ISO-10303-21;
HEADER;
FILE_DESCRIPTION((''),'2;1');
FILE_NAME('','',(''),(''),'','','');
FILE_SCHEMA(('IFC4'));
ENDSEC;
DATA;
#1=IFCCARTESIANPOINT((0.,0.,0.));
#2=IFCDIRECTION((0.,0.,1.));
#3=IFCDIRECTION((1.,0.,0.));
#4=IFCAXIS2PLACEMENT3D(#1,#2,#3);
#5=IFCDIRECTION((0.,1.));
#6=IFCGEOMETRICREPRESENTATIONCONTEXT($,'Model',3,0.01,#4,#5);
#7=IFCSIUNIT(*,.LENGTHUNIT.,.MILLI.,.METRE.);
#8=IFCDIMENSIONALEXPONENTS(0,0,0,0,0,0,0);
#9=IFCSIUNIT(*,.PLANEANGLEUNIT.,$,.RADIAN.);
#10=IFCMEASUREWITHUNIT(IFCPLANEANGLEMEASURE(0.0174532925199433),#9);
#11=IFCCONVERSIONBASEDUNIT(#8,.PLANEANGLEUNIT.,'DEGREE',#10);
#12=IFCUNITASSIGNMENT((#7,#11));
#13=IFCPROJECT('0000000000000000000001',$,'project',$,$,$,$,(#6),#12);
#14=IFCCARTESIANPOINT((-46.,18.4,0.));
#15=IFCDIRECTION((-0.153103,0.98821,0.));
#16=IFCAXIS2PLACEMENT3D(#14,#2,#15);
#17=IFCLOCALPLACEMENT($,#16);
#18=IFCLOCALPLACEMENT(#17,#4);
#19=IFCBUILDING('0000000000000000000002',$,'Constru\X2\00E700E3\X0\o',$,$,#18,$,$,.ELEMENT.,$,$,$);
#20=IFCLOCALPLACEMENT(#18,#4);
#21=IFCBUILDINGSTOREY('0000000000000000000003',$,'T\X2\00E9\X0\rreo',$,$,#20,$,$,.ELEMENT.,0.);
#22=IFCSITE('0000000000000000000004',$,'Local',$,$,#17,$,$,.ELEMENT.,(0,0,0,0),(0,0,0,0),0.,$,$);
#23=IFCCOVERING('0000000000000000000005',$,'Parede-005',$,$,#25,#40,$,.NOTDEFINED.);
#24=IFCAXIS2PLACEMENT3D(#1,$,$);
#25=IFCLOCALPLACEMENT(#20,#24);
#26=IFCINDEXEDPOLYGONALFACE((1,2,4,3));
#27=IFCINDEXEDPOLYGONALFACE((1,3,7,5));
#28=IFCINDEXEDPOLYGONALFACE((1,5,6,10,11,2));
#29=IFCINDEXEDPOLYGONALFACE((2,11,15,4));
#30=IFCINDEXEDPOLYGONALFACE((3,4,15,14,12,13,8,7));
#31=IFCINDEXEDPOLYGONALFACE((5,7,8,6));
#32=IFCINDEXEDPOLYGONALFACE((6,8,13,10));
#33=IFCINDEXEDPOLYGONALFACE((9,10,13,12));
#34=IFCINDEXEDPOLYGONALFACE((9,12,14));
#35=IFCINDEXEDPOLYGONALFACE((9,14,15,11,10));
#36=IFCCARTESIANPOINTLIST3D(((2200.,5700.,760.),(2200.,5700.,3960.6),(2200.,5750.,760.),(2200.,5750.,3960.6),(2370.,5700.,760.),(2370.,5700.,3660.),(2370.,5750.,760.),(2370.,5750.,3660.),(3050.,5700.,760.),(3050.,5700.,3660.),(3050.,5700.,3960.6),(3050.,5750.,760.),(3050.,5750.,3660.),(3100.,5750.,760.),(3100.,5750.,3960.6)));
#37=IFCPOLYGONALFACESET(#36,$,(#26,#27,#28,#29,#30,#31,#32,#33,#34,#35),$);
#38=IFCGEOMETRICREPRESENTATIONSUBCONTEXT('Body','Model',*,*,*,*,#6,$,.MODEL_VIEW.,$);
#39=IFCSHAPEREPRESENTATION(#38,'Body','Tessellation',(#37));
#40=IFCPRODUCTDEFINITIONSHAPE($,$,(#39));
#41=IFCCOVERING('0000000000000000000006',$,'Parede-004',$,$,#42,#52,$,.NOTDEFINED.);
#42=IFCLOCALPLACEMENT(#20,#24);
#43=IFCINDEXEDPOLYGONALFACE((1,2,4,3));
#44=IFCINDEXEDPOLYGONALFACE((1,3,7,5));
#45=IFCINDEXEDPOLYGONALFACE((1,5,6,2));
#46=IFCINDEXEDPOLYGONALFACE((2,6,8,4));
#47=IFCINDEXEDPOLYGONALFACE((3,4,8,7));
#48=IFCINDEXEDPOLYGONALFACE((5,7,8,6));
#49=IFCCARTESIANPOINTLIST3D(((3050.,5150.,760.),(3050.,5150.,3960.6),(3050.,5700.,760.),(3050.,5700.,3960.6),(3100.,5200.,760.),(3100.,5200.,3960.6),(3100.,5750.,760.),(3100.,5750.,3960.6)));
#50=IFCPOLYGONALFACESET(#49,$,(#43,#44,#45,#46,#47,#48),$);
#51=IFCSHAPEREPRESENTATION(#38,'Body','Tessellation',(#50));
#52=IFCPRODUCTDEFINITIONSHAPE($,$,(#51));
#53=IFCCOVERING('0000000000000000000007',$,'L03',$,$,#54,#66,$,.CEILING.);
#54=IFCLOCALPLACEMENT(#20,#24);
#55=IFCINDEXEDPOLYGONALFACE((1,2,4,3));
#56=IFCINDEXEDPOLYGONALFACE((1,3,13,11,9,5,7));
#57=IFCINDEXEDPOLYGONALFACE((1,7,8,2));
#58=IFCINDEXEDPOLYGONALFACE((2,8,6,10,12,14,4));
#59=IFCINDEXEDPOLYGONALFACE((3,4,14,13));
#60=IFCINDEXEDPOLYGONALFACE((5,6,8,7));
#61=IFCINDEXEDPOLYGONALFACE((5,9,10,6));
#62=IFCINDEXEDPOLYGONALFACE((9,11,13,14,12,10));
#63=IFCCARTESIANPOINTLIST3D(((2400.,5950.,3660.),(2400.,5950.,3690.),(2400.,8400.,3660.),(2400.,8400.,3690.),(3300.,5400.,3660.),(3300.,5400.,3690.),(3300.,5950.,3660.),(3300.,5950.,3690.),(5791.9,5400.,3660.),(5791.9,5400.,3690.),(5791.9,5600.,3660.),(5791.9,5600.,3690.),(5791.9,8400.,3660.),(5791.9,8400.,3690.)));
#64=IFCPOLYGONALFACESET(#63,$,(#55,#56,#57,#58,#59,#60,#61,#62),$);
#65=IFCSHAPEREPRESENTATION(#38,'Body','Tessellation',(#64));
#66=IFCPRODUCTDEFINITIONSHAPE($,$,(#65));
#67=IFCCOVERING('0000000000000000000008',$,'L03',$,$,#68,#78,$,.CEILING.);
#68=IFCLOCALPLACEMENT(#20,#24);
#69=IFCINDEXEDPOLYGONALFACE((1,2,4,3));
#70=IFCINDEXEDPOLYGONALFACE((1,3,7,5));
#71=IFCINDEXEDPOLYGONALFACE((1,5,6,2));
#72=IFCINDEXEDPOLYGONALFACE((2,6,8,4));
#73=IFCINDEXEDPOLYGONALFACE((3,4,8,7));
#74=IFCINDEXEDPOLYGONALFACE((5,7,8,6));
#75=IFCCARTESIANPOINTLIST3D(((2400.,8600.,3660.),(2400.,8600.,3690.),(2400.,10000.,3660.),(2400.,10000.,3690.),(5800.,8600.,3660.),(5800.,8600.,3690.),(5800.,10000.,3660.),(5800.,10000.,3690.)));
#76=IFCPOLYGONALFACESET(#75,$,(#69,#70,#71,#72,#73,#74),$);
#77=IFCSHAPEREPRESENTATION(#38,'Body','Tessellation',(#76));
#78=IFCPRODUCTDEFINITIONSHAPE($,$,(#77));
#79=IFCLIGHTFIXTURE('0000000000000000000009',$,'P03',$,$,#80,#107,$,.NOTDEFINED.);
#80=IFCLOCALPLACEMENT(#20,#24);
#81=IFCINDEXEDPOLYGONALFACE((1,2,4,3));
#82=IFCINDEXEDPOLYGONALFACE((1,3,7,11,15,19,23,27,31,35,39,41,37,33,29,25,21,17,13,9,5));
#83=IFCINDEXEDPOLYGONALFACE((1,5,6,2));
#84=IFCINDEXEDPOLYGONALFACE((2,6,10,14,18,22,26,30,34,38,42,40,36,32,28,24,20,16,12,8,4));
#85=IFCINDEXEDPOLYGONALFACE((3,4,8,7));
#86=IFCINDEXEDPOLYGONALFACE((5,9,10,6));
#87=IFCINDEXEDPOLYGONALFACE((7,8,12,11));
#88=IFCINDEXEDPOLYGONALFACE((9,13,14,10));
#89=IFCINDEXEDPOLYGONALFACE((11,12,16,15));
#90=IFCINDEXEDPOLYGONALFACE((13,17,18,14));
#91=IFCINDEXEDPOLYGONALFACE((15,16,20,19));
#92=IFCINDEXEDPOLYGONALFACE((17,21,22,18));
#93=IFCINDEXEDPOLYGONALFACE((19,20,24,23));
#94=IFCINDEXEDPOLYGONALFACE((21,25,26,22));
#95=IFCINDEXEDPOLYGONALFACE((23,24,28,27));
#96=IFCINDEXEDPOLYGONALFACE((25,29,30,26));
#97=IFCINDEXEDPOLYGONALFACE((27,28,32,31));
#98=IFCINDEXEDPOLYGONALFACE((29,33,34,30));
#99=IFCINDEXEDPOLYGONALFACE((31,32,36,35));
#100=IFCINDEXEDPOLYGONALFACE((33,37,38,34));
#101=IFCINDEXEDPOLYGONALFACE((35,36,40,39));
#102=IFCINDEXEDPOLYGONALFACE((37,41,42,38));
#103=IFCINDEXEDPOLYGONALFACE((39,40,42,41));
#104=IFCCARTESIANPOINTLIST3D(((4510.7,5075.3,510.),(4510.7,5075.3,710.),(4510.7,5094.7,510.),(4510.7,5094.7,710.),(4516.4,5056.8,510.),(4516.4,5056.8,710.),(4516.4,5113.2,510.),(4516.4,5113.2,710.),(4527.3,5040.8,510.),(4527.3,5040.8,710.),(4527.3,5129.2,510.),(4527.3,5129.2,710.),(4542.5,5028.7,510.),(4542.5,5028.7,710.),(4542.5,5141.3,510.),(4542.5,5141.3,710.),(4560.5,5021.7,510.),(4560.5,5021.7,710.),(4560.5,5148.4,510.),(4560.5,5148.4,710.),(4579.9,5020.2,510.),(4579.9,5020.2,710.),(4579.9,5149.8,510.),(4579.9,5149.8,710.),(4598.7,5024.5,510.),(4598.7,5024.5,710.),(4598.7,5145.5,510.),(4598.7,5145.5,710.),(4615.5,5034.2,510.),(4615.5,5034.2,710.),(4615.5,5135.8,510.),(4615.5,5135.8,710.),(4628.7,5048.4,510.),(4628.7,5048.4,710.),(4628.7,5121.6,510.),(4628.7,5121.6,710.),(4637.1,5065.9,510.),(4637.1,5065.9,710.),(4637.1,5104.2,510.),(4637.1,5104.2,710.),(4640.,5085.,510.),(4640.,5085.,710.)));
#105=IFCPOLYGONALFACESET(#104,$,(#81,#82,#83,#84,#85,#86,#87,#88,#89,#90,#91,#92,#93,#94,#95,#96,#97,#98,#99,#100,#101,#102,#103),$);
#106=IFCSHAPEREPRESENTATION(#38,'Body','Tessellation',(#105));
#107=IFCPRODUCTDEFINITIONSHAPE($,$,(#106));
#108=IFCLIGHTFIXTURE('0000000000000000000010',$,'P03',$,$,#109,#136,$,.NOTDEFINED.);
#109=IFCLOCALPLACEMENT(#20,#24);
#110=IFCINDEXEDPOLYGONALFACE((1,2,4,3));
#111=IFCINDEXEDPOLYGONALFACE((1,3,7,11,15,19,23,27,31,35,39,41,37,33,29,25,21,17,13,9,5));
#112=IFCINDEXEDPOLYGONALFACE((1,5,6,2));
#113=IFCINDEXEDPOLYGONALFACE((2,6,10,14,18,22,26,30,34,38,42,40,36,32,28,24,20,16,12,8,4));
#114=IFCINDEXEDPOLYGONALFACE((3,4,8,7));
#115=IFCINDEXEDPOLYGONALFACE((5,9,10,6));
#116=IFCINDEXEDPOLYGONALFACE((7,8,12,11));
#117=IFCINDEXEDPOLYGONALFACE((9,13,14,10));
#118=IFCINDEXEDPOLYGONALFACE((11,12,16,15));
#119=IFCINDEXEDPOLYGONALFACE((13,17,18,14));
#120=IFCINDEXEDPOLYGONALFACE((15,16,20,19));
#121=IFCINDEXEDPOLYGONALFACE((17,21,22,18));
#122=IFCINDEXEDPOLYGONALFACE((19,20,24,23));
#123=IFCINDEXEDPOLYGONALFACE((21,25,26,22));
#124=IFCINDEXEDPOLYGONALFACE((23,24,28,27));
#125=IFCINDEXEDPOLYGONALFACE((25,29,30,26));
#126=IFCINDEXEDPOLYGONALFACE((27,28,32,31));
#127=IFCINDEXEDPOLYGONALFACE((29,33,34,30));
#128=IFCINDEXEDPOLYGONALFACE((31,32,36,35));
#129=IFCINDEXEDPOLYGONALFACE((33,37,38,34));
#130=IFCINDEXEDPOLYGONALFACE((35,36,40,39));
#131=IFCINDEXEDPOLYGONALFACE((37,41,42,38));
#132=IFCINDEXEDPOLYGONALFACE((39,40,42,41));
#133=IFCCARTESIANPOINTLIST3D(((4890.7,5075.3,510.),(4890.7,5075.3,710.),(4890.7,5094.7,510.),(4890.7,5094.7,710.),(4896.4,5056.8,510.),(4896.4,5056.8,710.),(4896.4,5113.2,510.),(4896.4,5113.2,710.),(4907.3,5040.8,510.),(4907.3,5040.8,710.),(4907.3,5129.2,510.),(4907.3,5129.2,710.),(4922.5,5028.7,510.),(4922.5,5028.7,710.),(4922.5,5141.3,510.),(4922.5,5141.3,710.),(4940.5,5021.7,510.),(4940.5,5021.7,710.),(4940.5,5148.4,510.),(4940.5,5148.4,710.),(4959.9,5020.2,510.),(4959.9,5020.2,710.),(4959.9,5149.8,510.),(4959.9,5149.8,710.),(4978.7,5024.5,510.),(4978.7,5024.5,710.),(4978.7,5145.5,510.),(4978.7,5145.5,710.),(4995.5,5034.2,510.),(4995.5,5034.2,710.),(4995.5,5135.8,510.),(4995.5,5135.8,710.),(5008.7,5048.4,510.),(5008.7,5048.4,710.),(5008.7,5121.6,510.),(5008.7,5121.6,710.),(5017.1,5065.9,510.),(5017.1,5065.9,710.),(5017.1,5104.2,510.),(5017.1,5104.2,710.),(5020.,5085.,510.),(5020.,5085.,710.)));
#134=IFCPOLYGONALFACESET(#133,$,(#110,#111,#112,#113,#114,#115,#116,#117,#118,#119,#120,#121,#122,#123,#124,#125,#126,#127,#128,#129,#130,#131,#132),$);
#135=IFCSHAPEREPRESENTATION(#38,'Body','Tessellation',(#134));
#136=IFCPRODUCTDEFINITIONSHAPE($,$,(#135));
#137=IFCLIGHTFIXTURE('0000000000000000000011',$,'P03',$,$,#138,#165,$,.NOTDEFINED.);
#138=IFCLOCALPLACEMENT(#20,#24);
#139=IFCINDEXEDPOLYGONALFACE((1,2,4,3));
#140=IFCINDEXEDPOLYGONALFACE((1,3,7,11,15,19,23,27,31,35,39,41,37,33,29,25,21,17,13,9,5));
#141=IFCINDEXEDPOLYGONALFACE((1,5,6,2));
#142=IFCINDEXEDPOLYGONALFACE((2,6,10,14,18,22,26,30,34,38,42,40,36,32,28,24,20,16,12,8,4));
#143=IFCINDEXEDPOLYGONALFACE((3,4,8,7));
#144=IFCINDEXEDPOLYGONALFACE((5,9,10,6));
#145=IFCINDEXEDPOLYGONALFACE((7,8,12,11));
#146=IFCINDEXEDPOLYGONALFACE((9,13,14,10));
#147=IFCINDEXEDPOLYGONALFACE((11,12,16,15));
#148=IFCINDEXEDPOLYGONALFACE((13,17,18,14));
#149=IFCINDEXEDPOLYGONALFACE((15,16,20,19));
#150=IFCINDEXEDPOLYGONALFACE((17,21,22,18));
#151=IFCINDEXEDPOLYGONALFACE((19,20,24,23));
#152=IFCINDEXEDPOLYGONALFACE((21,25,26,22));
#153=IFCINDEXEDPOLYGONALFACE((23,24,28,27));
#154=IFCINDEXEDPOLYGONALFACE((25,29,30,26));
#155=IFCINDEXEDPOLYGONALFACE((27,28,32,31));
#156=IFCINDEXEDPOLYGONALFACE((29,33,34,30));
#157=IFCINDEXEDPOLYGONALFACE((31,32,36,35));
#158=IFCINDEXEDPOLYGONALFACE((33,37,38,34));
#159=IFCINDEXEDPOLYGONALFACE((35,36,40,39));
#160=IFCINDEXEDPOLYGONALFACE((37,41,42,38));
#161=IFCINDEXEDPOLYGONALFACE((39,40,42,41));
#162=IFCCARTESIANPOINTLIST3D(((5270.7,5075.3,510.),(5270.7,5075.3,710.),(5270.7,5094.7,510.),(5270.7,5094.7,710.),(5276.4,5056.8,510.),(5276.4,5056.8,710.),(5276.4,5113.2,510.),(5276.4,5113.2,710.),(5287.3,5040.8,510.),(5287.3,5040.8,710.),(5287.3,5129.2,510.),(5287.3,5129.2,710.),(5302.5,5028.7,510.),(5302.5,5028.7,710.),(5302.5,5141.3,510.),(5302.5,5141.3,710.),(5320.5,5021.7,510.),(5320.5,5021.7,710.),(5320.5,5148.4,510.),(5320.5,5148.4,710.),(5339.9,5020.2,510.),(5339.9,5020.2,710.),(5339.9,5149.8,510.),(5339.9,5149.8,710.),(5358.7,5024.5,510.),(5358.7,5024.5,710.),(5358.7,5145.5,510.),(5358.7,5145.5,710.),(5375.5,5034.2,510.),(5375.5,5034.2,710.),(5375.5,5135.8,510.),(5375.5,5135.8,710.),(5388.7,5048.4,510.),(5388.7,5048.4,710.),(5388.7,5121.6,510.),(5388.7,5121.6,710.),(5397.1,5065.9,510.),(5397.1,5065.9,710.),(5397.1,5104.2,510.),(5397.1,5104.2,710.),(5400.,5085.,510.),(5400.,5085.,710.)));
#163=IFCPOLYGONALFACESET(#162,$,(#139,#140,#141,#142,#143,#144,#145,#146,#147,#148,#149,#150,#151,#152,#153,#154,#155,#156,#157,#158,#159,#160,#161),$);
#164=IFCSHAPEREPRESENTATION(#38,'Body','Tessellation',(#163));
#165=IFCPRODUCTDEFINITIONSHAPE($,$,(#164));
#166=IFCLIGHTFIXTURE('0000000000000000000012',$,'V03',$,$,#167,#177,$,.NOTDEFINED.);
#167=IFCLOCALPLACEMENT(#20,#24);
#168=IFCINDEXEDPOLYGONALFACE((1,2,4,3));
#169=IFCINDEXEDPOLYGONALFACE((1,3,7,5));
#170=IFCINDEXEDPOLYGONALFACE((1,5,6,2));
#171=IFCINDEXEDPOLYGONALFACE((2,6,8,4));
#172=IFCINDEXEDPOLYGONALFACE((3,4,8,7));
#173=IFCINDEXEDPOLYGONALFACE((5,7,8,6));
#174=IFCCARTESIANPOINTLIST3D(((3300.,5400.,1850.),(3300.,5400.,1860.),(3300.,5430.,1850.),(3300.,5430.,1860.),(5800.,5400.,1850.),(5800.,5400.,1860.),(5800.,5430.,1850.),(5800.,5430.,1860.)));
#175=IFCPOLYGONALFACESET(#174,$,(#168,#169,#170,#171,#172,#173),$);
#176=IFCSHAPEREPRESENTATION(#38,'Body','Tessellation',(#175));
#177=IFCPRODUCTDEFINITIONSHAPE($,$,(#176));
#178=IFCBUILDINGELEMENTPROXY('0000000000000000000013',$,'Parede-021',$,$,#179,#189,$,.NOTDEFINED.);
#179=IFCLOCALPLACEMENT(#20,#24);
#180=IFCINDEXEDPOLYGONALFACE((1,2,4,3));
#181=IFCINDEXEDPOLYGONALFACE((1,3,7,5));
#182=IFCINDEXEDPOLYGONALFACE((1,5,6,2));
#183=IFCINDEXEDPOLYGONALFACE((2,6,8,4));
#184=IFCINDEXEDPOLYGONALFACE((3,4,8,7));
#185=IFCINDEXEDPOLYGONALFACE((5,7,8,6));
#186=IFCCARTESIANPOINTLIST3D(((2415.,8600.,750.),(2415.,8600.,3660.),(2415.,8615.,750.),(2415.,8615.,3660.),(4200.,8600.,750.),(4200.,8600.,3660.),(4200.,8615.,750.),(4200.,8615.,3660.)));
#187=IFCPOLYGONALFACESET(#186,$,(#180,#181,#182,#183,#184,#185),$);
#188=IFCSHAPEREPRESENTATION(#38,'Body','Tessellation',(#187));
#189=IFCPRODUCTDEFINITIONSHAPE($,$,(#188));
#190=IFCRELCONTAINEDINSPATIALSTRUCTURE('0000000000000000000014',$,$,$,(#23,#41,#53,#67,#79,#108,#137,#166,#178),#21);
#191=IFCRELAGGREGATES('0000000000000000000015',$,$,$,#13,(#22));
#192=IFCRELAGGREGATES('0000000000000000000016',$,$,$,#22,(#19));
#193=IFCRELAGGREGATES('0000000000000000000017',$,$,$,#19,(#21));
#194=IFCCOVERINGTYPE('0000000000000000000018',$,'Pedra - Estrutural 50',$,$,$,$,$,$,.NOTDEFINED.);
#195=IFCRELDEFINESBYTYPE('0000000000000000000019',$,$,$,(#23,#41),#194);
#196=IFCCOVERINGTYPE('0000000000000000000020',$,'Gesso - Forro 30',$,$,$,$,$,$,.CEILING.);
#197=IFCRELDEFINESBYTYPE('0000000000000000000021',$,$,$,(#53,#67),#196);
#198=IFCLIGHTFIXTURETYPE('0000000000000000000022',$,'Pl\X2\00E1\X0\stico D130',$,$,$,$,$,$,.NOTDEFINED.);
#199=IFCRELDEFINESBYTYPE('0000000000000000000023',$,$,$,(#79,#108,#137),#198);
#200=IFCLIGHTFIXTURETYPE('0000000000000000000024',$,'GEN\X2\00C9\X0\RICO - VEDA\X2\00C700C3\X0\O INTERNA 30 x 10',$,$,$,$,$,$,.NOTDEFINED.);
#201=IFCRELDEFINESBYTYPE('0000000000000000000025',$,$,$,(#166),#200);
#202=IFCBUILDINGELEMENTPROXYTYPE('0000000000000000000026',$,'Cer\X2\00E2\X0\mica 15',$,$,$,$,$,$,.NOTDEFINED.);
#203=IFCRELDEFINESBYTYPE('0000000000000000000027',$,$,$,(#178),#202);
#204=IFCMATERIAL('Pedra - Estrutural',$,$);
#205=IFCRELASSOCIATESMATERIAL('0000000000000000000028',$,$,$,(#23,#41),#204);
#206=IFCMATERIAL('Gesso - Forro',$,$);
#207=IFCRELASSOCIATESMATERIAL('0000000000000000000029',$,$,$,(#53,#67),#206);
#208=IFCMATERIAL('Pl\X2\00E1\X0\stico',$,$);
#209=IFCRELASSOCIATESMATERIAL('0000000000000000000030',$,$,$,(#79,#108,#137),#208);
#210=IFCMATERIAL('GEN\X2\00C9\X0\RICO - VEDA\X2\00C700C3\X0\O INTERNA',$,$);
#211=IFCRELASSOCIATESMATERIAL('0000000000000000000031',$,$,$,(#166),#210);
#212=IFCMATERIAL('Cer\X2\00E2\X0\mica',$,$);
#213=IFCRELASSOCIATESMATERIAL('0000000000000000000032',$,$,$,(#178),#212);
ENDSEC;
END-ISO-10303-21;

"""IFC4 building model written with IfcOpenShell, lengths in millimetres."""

from ifc_helpers import new_model, entity, si_unit, converted_unit, direction, frame, frame_2d, origin_with_axes, origin_2d_with_axis, place, context, subcontext, project, spatial, line, indexed_curve, rectangle, circle, outline, extrude, material, type_object, element, save


model = new_model("IFC4")

# Units and contexts
model_context = context("Model", 3, precision=0.01, world=origin_with_axes(), true_north=direction((0.0, 1.0)))
body_context = subcontext(model_context, "Body", "Model", "MODEL_VIEW")
ifc_project = project(units=[si_unit("LENGTHUNIT", "METRE", prefix="MILLI"), converted_unit("PLANEANGLEUNIT", "DEGREE", entity("IfcPlaneAngleMeasure", 0.0174532925199433), si_unit("PLANEANGLEUNIT", "RADIAN"), dimensions=[0, 0, 0, 0, 0, 0, 0])], contexts=[model_context])

# Site, building, storey
site_placement = place(None, frame((-46.0, 18.4, 0.0), z_axis=(0.0, 0.0, 1.0), x_axis=(-0.153103, 0.98821, 0.0)))
site = spatial("IfcSite", under=ifc_project, at=site_placement, Name="Local", CompositionType="ELEMENT", RefLatitude=(0, 0, 0, 0), RefLongitude=(0, 0, 0, 0), RefElevation=0.0)
building_placement = place(site_placement, origin_with_axes())
building = spatial("IfcBuilding", under=site, at=building_placement, Name="Construção", CompositionType="ELEMENT")
storey_placement = place(building_placement, origin_with_axes())
storey = spatial("IfcBuildingStorey", under=building, at=storey_placement, Name="Térreo", CompositionType="ELEMENT", Elevation=0.0)

# Shared definitions
ifc_material_1 = material(Name="GENÉRICO - VEDAÇÃO INTERNA")

# Covering, opening
ifc_material_2 = material(Name="Pedra - Estrutural")
covering_type_1 = type_object("IfcCoveringType", Name="Pedra - Estrutural 50", PredefinedType="NOTDEFINED")
covering_1_placement = place(storey_placement, frame((3100.0, 5750.0, 760.0), z_axis=(0.0, 0.0, 1.0), x_axis=(-1.0, 0.0, 0.0)))
covering_1 = element("IfcCovering", 1, at=covering_1_placement, inside=storey, type_object=covering_type_1, material=ifc_material_2, Name="Parede-005", PredefinedType="NOTDEFINED", context=body_context, shape_type="SweptSolid", body=[
    extrude(outline(indexed_curve([(0.0, 0.0), (900.0, 0.0), (900.0, 50.0), (50.0, 50.0)], segments=[line(1, 2, 3, 4, 1)])), origin_with_axes(), (0.0, 0.0, 1.0), 3200.6),
])
opening_1_placement = place(covering_1_placement, frame((390.0, 0.0, 0.0), z_axis=(0.0, 0.0, 1.0), x_axis=(1.0, 0.0, 0.0)))
element("IfcOpeningElement", 2, at=opening_1_placement, cuts=covering_1, context=body_context, shape_type="SweptSolid", body=[
    extrude(rectangle(XDim=680.0, YDim=2900.0, at=origin_2d_with_axis()), frame((0.0, -50.0, 1450.0), z_axis=(0.0, 1.0, 0.0), x_axis=(-1.0, 0.0, 0.0)), (0.0, 0.0, 1.0), 150.0),
])

# Coverings
covering_2_placement = place(storey_placement, frame((3100.0, 5200.0, 760.0), z_axis=(0.0, 0.0, 1.0), x_axis=(-0.000001, 1.0, 0.0)))
element("IfcCovering", 3, at=covering_2_placement, inside=storey, type_object=covering_type_1, material=ifc_material_2, Name="Parede-004", PredefinedType="NOTDEFINED", context=body_context, shape_type="SweptSolid", body=[
    extrude(outline(indexed_curve([(0.0, 0.0), (550.0, 0.0), (500.0, 50.0), (-50.0, 50.0)], segments=[line(1, 2, 3, 4, 1)])), origin_with_axes(), (0.0, 0.0, 1.0), 3200.6),
])
ifc_material_3 = material(Name="Gesso - Forro")
covering_type_2 = type_object("IfcCoveringType", Name="Gesso - Forro 30", PredefinedType="CEILING")
covering_3_placement = place(storey_placement, frame((2400.0, 8400.0, 3690.0), z_axis=(0.0, 0.0, 1.0), x_axis=(1.0, 0.0, 0.0)))
element("IfcCovering", 4, at=covering_3_placement, inside=storey, type_object=covering_type_2, material=ifc_material_3, Name="L03", PredefinedType="CEILING", context=body_context, shape_type="SweptSolid", body=[
    extrude(outline(indexed_curve([(0.0, 0.0), (0.0, -2450.0), (900.0, -2450.0), (900.0, -3000.0), (3391.9, -3000.0), (3391.9, -2800.0), (3391.9, 0.0)], segments=[line(1, 2, 3, 4, 5, 6, 7, 1)])), frame((0.0, 0.0, -30.0), z_axis=(0.0, 0.0, 1.0), x_axis=(1.0, 0.0, 0.0)), (0.0, 0.0, 1.0), 30.0),
])
covering_4_placement = place(storey_placement, frame((2400.0, 8600.0, 3690.0), z_axis=(0.0, 0.0, 1.0), x_axis=(1.0, 0.0, 0.0)))
element("IfcCovering", 5, at=covering_4_placement, inside=storey, type_object=covering_type_2, material=ifc_material_3, Name="L03", PredefinedType="CEILING", context=body_context, shape_type="SweptSolid", body=[
    extrude(outline(indexed_curve([(0.0, 0.0), (3400.0, 0.0), (3400.0, 1400.0), (0.0, 1400.0)], segments=[line(1, 2, 3, 4, 1)])), frame((0.0, 0.0, -30.0), z_axis=(0.0, 0.0, 1.0), x_axis=(1.0, 0.0, 0.0)), (0.0, 0.0, 1.0), 30.0),
])

# Light fixtures
ifc_material_4 = material(Name="Plástico")
light_fixture_type_1 = type_object("IfcLightFixtureType", Name="Plástico D130", PredefinedType="NOTDEFINED")
for number, where, z_axis, x_axis, name in (
    (6, (4575.0, 5085.0, 510.0), (0.0, 0.0, 1.0), (1.0, 0.0, 0.0), "P03"),
    (7, (4955.0, 5085.0, 510.0), (0.0, 0.0, 1.0), (1.0, 0.0, 0.0), "P03"),
    (8, (5335.0, 5085.0, 510.0), (0.0, 0.0, 1.0), (1.0, 0.0, 0.0), "P03"),
):
    element("IfcLightFixture", number, at=place(storey_placement, frame(where, z_axis=z_axis, x_axis=x_axis)), inside=storey, type_object=light_fixture_type_1, material=ifc_material_4, Name=name, PredefinedType="NOTDEFINED", context=body_context, shape_type="SweptSolid", body=[
        extrude(circle(Radius=65.0, at=origin_2d_with_axis()), origin_with_axes(), (0.0, 0.0, 1.0), 200.0),
    ])
light_fixture_type_2 = type_object("IfcLightFixtureType", Name="GENÉRICO - VEDAÇÃO INTERNA 30 x 10", PredefinedType="NOTDEFINED")
light_fixture_placement = place(storey_placement, frame((3300.0, 5400.0, 1860.0), z_axis=(0.0, 0.0, 1.0), x_axis=(0.0, -1.0, 0.0)))
element("IfcLightFixture", 9, at=light_fixture_placement, inside=storey, type_object=light_fixture_type_2, material=ifc_material_1, Name="V03", PredefinedType="NOTDEFINED", context=body_context, shape_type="SweptSolid", body=[
    extrude(rectangle(XDim=10.0, YDim=30.0, at=frame_2d((-5.0, -15.0), x_axis=(1.0, 0.0))), frame((0.0, 0.0, 0.0), z_axis=(0.0, 1.0, 0.0), x_axis=(0.0, 0.0, 1.0)), (0.0, 0.0, 1.0), 2500.0),
])

# Building element proxy
ifc_material_5 = material(Name="Cerâmica")
building_element_proxy_type_1 = type_object("IfcBuildingElementProxyType", Name="Cerâmica 15", PredefinedType="NOTDEFINED")
proxy_1_placement = place(storey_placement, frame((2415.0, 8600.0, 750.0), z_axis=(0.0, 0.0, 1.0), x_axis=(1.0, 0.0, 0.0)))
element("IfcBuildingElementProxy", 10, at=proxy_1_placement, inside=storey, type_object=building_element_proxy_type_1, material=ifc_material_5, Name="Parede-021", PredefinedType="NOTDEFINED", context=body_context, shape_type="SweptSolid", body=[
    extrude(outline(indexed_curve([(0.0, 0.0), (1785.0, 0.0), (1785.0, 15.0), (0.0, 15.0)], segments=[line(1, 2, 3, 4, 1)])), origin_with_axes(), (0.0, 0.0, 1.0), 2910.0),
])

save(model, "model.ifc")
